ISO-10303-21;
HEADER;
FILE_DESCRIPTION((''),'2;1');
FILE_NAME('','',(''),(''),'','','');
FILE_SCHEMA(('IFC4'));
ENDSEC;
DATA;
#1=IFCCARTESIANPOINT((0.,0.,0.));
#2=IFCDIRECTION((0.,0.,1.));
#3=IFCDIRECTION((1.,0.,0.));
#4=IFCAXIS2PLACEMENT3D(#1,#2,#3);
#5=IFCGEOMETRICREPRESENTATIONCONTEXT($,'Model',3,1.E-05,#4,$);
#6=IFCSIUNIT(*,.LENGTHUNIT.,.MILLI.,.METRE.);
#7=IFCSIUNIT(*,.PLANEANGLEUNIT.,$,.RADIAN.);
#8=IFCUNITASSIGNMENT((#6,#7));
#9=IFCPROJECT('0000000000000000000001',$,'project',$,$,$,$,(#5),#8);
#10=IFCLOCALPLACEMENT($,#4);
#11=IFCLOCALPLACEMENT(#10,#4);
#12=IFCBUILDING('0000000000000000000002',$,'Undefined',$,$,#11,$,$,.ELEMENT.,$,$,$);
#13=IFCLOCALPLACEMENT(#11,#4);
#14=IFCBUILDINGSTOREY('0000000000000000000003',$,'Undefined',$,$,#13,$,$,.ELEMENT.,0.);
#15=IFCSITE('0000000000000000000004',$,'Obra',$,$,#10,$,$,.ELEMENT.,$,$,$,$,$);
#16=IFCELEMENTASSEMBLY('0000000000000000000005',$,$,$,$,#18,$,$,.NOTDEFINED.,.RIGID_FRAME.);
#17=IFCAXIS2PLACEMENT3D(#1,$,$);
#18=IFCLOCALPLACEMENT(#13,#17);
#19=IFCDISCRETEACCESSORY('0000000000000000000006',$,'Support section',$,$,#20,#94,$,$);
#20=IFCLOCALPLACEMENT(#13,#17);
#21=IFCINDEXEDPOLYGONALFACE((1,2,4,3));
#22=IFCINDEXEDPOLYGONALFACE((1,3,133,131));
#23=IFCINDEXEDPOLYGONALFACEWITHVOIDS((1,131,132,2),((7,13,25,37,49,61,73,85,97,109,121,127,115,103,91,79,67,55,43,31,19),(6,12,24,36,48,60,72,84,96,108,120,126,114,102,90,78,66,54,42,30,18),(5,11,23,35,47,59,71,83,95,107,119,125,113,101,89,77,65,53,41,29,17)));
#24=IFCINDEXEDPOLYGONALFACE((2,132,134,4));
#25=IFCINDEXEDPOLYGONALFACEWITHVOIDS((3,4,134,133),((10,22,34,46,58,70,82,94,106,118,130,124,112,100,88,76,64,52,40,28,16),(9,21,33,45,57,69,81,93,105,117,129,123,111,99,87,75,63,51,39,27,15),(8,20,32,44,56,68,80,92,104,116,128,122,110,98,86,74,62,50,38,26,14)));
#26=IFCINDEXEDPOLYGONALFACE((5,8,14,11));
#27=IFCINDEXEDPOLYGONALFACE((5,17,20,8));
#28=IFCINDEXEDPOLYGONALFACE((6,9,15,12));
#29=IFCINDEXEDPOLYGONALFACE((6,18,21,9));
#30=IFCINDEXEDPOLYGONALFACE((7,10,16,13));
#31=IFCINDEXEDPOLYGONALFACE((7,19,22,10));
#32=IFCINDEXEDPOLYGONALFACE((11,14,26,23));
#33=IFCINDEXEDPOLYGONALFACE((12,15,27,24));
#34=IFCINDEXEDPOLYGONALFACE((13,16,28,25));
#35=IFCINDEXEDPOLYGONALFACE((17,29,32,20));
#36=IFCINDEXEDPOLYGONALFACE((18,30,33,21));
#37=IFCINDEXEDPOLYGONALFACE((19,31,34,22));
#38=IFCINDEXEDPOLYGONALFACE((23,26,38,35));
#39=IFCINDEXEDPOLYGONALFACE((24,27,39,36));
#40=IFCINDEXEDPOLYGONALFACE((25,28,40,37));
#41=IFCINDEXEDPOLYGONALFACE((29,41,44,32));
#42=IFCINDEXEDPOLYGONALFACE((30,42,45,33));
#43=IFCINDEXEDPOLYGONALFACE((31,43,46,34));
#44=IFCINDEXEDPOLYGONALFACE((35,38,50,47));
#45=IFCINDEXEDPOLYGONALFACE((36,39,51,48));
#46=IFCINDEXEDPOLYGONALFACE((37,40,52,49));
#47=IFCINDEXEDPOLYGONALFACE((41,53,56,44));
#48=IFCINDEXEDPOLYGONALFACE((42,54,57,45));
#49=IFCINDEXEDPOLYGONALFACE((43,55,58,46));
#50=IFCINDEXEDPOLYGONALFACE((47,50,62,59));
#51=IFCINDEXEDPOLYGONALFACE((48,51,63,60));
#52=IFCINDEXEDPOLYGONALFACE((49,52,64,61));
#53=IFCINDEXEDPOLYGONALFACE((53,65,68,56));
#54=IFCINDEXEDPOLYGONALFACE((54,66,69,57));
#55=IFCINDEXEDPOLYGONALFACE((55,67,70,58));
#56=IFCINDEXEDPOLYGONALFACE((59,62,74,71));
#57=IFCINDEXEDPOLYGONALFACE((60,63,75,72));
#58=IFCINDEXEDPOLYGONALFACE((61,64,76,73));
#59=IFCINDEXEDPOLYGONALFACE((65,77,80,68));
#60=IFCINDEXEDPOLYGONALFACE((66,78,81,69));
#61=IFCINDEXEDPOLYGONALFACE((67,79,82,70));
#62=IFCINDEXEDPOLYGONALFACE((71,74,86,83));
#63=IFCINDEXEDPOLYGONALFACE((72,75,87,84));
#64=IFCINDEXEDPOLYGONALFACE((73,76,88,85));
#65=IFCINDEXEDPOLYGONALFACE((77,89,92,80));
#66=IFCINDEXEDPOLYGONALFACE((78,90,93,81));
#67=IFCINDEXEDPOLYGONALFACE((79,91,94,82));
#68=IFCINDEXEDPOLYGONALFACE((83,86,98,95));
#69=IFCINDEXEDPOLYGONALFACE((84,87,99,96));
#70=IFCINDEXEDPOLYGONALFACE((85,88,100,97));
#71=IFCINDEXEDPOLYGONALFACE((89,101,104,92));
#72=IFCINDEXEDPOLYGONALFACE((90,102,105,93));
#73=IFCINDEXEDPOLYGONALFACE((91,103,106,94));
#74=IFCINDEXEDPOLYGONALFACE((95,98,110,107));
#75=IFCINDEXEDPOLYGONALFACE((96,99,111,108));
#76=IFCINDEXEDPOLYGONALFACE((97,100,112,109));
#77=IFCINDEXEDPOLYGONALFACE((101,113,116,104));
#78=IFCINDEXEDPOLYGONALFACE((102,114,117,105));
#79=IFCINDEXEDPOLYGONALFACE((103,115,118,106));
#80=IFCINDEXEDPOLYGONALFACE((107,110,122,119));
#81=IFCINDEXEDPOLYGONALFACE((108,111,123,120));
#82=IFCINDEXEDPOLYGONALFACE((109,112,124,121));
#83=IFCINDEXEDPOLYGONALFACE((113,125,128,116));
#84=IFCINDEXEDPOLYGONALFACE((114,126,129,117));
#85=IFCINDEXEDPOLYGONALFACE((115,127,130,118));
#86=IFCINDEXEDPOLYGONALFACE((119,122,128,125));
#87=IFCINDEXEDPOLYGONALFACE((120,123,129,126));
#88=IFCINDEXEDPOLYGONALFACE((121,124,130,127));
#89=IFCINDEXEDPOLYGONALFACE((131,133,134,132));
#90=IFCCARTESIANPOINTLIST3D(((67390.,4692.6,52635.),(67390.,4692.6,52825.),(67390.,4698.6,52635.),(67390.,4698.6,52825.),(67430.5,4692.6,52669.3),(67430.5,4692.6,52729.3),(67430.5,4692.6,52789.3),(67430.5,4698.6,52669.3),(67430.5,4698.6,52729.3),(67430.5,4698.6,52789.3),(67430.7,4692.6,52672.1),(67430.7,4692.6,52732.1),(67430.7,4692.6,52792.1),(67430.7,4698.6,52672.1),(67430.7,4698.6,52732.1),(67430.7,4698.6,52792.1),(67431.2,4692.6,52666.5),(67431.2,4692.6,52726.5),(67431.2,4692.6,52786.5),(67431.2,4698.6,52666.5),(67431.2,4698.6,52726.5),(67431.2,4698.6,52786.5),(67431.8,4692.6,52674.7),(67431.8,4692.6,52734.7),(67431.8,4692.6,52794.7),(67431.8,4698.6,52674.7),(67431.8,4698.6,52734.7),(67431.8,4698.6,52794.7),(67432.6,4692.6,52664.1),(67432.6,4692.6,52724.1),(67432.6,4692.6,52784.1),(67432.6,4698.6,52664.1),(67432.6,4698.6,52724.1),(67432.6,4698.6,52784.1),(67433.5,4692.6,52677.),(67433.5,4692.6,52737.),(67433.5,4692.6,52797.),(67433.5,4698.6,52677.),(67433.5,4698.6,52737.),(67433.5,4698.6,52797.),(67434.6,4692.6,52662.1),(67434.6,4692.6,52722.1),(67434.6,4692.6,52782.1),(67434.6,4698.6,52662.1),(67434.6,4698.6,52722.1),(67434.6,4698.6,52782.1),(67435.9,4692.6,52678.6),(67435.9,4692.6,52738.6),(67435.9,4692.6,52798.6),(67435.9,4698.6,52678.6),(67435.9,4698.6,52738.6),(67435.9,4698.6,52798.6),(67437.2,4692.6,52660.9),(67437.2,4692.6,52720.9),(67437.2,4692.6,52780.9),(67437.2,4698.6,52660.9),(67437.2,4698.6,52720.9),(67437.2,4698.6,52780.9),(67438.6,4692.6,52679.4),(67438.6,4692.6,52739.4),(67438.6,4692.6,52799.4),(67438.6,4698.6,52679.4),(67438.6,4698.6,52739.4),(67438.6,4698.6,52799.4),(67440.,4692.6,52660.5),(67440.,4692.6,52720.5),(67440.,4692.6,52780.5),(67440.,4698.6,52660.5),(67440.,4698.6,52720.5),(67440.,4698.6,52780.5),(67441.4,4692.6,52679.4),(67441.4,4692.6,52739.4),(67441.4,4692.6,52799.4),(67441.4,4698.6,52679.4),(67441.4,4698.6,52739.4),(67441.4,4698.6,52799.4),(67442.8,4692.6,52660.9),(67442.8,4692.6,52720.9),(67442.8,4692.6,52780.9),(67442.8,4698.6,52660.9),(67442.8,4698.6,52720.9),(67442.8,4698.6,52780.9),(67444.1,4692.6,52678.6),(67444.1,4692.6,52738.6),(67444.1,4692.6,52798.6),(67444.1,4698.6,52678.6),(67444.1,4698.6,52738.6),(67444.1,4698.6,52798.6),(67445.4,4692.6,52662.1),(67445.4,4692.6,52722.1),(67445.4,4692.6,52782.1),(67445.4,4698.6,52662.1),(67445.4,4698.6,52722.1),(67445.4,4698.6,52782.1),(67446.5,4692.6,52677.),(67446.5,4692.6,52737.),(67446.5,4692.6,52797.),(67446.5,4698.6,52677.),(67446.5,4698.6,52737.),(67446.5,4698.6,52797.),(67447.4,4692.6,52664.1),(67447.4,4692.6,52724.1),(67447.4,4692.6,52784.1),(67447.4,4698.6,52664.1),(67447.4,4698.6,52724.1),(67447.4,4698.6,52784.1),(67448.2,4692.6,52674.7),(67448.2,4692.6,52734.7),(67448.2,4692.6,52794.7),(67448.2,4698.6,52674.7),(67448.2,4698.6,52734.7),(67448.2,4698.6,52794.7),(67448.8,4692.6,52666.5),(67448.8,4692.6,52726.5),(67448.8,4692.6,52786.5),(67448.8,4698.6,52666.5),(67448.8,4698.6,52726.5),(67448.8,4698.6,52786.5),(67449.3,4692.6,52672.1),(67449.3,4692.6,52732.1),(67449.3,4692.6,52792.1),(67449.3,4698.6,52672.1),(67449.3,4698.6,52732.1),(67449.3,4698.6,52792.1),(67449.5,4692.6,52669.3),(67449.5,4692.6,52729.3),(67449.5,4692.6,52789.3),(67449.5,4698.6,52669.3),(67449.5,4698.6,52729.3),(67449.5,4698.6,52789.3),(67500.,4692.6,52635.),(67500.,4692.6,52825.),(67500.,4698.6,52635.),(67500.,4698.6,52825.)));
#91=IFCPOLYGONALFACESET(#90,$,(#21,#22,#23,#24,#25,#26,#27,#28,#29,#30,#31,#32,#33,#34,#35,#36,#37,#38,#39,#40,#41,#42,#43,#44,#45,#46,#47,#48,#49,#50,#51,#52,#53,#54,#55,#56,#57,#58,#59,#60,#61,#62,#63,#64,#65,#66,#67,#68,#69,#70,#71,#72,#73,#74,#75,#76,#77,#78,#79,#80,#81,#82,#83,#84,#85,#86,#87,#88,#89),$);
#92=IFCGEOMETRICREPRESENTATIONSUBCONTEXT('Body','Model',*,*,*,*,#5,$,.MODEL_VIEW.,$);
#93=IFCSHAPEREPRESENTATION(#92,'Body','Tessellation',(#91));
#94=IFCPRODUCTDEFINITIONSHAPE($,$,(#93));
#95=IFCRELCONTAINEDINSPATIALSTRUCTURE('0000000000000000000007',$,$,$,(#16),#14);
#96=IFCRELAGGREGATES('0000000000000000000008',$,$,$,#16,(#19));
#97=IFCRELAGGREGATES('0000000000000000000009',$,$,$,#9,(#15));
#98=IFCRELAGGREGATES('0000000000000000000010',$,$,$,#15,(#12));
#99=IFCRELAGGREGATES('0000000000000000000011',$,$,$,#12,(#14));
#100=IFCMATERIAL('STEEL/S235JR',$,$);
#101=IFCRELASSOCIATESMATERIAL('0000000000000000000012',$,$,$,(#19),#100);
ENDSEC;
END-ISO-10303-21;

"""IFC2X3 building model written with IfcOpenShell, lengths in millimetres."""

from ifc_helpers import new_model, si_unit, frame, origin_with_axes, origin_2d_with_axis, place, context, subcontext, project, spatial, rectangle, circle, extrude, source, transform, mapped, material, element, aggregate, save


model = new_model("IFC2X3")

# Units and contexts
model_context = context("Model", 3, precision=1e-05, world=origin_with_axes())
body_context = subcontext(model_context, "Body", "Model", "MODEL_VIEW")
ifc_project = project(units=[si_unit("LENGTHUNIT", "METRE", prefix="MILLI"), si_unit("PLANEANGLEUNIT", "RADIAN")], contexts=[model_context])

# Site, building, storey
site_placement = place(None, origin_with_axes())
site = spatial("IfcSite", under=ifc_project, at=site_placement, Name="Obra", CompositionType="ELEMENT")
building_placement = place(site_placement, origin_with_axes())
building = spatial("IfcBuilding", under=site, at=building_placement, Name="Undefined", CompositionType="ELEMENT")
storey_placement = place(building_placement, origin_with_axes())
storey = spatial("IfcBuildingStorey", under=building, at=storey_placement, Name="Undefined", CompositionType="ELEMENT", Elevation=0.0)

# Element assembly
ifc_material_1 = material(Name="STEEL/S235JR")
assembly_1_placement = place(storey_placement, origin_with_axes())
assembly_1 = element("IfcElementAssembly", 1, at=assembly_1_placement, inside=storey, AssemblyPlace="NOTDEFINED", PredefinedType="RIGID_FRAME")

# Discrete accessory, opening
shared_shape_1 = source(origin_with_axes(), body_context, "Body", "SweptSolid", [
    extrude(circle(Radius=9.5, at=origin_2d_with_axis()), frame((0.0, -9.2, 0.0), z_axis=(0.0, 1.0, 0.0), x_axis=(1.0, 0.0, 0.0)), (0.0, 0.0, 1.0), 6.2),
])
discrete_accessory_1_placement = place(assembly_1_placement, frame((67445.0, 4695.6, 52635.0), z_axis=(0.0, 0.0, 1.0), x_axis=(1.0, 0.0, 0.0)))
discrete_accessory_1 = element("IfcDiscreteAccessory", 2, at=discrete_accessory_1_placement, material=ifc_material_1, Name="Support section", context=body_context, shape_type="SweptSolid", body=[
    extrude(rectangle(XDim=6.0, YDim=110.0, at=origin_2d_with_axis()), frame((0.0, 0.0, 190.0), z_axis=(0.0, 0.0, -1.0), x_axis=(0.0, 1.0, 0.0)), (0.0, 0.0, 1.0), 190.0),
])
opening_1_placement = place(assembly_1_placement, frame((67490.0, 4689.5, 52850.0), z_axis=(-1.0, 0.0, 0.0), x_axis=(0.0, 0.0, -1.0)))
element("IfcOpeningElement", 3, at=opening_1_placement, cuts=discrete_accessory_1, ObjectType="Opening", context=body_context, shape_type="MappedRepresentation", body=[
    mapped(shared_shape_1, transform((60.0, 0.0, 50.0))),
    mapped(shared_shape_1, transform((120.0, 0.0, 50.0))),
    mapped(shared_shape_1, transform((180.0, 0.0, 50.0))),
])
aggregate(assembly_1, [discrete_accessory_1])

save(model, "model.ifc")
